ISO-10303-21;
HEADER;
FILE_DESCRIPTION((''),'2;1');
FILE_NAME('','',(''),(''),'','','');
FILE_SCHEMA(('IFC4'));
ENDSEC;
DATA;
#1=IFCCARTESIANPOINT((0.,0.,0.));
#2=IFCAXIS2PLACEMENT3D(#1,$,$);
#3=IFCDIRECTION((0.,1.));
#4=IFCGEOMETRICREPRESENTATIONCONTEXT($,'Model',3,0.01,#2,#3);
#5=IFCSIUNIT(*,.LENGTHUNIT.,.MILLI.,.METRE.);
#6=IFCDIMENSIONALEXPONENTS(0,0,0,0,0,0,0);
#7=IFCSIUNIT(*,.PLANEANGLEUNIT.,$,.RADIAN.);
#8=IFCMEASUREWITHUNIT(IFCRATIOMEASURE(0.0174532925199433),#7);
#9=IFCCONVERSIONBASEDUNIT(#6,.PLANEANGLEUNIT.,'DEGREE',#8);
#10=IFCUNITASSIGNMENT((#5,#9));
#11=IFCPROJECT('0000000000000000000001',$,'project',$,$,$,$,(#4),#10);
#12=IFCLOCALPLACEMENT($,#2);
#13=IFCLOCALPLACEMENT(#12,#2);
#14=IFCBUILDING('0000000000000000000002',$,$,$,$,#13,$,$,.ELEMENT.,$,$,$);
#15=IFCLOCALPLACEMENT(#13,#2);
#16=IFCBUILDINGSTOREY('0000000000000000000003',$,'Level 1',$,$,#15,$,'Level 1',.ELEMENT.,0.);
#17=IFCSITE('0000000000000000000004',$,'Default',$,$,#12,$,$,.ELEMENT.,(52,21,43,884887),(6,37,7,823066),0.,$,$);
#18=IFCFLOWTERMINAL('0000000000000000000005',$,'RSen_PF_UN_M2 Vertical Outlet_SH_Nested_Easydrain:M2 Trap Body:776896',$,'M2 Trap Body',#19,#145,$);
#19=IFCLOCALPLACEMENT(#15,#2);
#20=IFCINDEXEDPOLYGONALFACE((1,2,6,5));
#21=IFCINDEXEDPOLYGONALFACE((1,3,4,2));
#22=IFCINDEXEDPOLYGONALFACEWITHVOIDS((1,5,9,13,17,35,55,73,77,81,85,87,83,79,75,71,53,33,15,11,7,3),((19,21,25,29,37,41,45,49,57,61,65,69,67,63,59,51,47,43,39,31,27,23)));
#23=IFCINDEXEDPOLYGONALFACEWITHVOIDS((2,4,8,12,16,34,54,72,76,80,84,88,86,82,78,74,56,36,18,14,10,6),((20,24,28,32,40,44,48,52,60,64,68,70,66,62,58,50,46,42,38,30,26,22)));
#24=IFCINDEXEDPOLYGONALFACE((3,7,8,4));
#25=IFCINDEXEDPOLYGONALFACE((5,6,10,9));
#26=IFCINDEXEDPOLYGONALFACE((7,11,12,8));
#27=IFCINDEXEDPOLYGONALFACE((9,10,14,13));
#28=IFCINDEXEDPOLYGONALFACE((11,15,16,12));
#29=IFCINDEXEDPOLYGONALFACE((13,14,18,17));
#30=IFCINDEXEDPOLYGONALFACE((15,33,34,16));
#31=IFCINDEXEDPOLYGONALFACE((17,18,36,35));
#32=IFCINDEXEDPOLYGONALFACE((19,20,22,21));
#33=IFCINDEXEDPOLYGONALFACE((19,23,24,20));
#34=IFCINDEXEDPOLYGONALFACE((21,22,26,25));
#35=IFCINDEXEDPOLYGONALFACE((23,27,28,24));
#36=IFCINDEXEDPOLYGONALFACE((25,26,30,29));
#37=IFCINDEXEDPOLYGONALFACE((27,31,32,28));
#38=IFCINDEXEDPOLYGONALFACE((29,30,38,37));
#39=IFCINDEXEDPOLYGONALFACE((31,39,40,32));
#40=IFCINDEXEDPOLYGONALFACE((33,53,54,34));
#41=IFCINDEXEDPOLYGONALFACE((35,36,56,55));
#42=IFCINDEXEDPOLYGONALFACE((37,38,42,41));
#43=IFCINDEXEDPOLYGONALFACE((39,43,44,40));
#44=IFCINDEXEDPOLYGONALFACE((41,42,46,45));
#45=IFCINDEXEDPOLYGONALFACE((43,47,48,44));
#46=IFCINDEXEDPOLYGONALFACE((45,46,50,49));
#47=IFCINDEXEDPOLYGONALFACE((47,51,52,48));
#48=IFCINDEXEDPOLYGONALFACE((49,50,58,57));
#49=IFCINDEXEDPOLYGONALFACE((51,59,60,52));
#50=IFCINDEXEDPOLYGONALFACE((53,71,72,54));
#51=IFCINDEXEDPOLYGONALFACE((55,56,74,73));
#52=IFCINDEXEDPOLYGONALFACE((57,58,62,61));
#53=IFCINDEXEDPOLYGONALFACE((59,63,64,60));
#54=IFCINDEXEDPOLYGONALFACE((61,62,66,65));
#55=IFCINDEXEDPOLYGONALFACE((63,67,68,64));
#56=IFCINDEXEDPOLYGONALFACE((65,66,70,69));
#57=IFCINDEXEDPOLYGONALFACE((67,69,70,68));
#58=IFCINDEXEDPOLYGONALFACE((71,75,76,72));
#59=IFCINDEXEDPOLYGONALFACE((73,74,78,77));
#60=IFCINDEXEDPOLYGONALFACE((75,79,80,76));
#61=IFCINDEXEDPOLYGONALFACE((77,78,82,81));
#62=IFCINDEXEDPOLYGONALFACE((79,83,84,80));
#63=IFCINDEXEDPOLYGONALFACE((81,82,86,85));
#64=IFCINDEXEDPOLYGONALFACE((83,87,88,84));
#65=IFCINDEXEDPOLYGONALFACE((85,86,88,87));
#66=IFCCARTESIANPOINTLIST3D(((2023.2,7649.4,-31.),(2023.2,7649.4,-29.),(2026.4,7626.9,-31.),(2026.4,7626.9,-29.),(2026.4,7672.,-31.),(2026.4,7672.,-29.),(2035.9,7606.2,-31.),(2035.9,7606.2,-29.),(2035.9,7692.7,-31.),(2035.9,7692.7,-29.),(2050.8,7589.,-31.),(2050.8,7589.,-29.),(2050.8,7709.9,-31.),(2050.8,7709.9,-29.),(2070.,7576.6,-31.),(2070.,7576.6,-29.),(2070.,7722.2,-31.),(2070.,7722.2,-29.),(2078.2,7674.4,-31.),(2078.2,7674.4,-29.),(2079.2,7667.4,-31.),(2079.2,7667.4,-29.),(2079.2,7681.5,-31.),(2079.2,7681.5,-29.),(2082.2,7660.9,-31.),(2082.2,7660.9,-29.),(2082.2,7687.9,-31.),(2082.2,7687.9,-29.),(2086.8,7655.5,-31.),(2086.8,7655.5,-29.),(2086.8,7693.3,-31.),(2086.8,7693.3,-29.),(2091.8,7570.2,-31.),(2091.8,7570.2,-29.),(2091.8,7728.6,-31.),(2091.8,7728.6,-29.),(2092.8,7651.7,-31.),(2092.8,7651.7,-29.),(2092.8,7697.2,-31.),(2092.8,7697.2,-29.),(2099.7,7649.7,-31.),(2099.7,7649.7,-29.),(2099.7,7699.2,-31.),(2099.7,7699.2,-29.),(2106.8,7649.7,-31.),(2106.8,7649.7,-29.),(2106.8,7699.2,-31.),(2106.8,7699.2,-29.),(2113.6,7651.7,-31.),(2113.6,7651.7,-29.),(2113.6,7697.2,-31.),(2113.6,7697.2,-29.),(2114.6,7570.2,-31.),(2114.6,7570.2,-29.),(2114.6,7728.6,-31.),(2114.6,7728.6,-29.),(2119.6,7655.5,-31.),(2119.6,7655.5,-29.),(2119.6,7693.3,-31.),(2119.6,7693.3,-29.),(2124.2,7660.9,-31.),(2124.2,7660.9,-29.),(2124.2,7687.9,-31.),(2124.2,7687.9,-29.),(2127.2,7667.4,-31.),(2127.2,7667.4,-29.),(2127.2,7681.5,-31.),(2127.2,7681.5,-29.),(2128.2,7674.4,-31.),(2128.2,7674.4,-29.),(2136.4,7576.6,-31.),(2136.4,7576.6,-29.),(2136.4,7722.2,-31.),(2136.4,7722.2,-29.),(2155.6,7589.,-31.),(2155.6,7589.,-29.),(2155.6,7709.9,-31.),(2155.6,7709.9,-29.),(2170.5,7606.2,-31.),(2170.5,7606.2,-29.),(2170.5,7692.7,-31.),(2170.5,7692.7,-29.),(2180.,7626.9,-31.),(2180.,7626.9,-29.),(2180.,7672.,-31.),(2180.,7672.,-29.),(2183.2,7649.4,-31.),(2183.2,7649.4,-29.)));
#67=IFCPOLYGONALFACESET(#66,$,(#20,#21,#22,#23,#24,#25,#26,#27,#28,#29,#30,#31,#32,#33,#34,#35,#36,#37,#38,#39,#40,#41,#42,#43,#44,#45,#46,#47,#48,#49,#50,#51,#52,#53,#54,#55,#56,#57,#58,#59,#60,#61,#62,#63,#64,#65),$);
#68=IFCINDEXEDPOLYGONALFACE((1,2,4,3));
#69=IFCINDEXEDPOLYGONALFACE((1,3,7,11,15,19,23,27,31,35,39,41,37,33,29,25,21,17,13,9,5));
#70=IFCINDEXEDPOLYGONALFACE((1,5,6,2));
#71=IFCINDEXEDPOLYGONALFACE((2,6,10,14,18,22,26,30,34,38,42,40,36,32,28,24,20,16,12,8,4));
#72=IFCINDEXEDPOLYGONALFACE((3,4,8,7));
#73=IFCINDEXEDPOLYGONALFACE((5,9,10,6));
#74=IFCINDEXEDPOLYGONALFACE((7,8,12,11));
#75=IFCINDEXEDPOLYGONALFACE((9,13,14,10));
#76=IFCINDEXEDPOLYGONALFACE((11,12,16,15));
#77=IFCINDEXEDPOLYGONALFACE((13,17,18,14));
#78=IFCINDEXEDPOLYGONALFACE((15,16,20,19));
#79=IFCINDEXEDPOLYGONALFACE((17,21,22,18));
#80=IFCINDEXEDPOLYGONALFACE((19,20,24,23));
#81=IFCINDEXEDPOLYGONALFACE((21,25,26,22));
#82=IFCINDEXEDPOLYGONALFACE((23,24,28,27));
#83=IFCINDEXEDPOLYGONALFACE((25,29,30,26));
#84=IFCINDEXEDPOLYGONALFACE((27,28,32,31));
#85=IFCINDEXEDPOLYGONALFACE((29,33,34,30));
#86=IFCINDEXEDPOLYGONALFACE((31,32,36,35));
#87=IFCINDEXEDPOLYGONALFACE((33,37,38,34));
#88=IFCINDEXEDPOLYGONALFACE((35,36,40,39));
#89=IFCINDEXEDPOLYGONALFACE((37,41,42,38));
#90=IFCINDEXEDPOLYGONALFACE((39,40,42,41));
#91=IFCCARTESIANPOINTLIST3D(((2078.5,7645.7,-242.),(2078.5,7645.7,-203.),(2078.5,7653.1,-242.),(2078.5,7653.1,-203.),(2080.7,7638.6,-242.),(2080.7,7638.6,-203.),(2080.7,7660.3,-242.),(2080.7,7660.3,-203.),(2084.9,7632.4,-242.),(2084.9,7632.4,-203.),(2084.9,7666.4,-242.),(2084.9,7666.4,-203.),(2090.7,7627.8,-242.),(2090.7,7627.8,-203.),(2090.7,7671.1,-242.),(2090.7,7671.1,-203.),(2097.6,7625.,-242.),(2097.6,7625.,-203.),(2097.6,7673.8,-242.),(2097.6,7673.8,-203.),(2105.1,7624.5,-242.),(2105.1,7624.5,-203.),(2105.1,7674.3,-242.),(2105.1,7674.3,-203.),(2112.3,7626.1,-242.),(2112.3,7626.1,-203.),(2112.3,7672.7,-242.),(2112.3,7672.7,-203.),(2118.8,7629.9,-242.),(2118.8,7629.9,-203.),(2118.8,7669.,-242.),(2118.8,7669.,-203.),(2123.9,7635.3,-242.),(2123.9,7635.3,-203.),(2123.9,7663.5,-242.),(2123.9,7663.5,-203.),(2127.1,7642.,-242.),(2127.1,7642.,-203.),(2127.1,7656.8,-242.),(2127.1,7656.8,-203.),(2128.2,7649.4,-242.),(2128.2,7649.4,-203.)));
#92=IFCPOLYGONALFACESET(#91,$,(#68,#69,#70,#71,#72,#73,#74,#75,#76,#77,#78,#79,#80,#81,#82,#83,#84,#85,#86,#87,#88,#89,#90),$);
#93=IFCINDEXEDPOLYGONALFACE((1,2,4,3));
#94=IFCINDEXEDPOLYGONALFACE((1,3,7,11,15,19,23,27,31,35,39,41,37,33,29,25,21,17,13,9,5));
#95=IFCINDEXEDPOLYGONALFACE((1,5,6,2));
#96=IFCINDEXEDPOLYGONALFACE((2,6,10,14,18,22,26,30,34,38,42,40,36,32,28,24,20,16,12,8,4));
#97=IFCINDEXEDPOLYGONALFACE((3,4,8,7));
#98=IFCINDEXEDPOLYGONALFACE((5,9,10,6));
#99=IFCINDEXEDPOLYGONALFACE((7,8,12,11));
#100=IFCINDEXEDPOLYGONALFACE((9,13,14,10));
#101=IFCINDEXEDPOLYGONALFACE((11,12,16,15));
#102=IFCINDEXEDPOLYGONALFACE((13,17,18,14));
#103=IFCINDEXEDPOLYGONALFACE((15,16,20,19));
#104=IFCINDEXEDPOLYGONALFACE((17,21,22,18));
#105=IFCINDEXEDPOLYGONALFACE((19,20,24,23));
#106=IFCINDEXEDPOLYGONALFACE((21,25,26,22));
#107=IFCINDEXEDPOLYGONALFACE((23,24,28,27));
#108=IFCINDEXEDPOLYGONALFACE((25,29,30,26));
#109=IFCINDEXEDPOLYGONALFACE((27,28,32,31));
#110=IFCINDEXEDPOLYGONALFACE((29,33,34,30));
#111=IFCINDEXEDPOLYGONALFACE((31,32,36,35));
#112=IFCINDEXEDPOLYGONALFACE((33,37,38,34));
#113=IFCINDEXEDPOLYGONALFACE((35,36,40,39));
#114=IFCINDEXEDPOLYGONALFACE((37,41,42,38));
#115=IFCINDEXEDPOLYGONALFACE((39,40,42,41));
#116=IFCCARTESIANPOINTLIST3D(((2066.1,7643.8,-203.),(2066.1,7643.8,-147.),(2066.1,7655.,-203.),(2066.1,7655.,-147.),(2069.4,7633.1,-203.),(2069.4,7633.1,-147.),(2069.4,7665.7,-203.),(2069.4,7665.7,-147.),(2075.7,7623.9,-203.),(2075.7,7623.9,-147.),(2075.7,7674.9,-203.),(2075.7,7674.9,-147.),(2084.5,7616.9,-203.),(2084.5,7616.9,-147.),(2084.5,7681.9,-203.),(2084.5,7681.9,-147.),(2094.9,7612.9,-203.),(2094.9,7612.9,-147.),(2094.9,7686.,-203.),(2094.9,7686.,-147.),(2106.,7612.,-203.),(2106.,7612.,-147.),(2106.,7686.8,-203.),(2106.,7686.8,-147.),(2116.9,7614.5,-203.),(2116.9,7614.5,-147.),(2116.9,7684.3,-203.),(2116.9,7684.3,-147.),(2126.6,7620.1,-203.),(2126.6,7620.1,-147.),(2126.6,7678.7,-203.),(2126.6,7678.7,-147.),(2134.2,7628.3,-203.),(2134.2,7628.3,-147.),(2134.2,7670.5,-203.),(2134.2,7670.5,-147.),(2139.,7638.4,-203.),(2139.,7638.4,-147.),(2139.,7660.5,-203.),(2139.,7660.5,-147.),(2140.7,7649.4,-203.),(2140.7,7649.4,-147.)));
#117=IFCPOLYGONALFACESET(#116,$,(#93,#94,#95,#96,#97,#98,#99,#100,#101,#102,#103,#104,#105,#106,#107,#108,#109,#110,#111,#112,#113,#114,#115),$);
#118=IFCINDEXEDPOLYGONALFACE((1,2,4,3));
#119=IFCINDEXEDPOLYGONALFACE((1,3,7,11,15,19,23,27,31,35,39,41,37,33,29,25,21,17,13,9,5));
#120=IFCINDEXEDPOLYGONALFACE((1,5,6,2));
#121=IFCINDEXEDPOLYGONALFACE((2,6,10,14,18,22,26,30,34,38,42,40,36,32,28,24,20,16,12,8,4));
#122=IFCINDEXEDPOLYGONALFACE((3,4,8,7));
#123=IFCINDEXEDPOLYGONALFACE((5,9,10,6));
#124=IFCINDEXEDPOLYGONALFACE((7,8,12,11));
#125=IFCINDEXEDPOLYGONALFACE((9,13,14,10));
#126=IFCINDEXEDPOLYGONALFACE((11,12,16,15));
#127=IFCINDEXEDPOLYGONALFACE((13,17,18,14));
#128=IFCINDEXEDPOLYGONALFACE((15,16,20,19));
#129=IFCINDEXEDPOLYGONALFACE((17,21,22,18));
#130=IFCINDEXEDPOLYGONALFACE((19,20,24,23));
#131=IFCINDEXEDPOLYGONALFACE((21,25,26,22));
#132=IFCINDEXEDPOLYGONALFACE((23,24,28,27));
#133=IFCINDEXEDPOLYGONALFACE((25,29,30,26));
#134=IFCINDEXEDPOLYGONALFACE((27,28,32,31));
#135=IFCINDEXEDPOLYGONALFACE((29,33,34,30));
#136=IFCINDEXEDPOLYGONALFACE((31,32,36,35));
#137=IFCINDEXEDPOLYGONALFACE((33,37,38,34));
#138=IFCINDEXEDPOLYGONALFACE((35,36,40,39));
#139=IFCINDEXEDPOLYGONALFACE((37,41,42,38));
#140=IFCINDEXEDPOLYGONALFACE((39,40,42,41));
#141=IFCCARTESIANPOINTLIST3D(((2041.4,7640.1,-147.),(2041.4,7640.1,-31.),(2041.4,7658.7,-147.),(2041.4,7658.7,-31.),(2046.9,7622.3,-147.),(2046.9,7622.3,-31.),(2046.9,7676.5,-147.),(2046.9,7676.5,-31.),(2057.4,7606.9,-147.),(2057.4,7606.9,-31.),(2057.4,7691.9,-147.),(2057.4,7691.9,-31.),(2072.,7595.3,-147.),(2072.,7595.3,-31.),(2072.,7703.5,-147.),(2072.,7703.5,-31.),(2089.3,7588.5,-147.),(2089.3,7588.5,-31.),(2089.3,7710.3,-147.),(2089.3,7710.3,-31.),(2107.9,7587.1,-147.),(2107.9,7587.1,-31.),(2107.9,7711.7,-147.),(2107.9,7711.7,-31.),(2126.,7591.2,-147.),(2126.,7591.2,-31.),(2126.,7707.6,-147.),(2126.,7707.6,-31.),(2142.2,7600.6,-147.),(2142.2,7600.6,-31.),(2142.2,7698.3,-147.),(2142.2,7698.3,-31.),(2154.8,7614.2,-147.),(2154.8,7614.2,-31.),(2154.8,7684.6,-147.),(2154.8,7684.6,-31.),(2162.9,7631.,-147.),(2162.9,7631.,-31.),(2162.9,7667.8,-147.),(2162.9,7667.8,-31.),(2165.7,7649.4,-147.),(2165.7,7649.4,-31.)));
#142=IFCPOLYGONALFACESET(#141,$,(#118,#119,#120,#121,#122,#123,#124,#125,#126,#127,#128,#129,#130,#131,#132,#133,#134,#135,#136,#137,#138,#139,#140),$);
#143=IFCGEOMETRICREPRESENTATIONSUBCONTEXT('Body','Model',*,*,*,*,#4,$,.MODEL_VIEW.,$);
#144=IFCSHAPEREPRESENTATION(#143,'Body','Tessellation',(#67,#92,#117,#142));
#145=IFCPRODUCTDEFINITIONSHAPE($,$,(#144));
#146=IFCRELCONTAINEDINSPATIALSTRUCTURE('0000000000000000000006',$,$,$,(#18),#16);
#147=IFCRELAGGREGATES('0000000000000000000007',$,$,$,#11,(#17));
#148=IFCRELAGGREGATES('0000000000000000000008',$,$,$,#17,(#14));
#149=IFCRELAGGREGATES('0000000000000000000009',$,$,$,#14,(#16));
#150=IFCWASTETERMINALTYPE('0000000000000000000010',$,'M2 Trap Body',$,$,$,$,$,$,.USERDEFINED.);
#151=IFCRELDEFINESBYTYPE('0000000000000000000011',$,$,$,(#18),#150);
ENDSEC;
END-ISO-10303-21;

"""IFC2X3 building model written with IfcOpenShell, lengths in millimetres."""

from ifc_helpers import new_model, entity, si_unit, converted_unit, direction, frame, frame_2d, origin, origin_2d_with_axis, place, context, subcontext, project, spatial, circle_curve, parameter, trimmed, segment, composite_curve, circle, outline, extrude, source, transform, mapped, type_object, type_shapes, element, save


model = new_model("IFC2X3")

# Units and contexts
model_context = context("Model", 3, precision=0.01, world=origin(), true_north=direction((0.0, 1.0)))
body_context = subcontext(model_context, "Body", "Model", "MODEL_VIEW")
ifc_project = project(units=[si_unit("LENGTHUNIT", "METRE", prefix="MILLI"), converted_unit("PLANEANGLEUNIT", "DEGREE", entity("IfcRatioMeasure", 0.0174532925199433), si_unit("PLANEANGLEUNIT", "RADIAN"), dimensions=[0, 0, 0, 0, 0, 0, 0])], contexts=[model_context])

# Site, building, storey
site_placement = place(None, origin())
site = spatial("IfcSite", under=ifc_project, at=site_placement, Name="Default", CompositionType="ELEMENT", RefLatitude=(52, 21, 43, 884887), RefLongitude=(6, 37, 7, 823066), RefElevation=0.0)
building_placement = place(site_placement, origin())
building = spatial("IfcBuilding", under=site, at=building_placement, CompositionType="ELEMENT")
storey_placement = place(building_placement, origin())
storey = spatial("IfcBuildingStorey", under=building, at=storey_placement, Name="Level 1", LongName="Level 1", CompositionType="ELEMENT", Elevation=0.0)

# Flow terminal
waste_terminal_type_1 = type_object("IfcWasteTerminalType", Name="M2 Trap Body", PredefinedType="USERDEFINED")
shared_shape_1 = source(origin(), body_context, "Body", "SweptSolid", [
    extrude(outline(composite_curve([segment(trimmed(circle_curve(origin_2d_with_axis(), 80.0), [parameter(0.0)], [parameter(180.0)], True, "PARAMETER"), True, "CONTINUOUS"), segment(trimmed(circle_curve(origin_2d_with_axis(), 80.0), [parameter(180.0)], [parameter(360.0)], True, "PARAMETER"), True, "CONTINUOUS")], self_intersect=False), holes=[composite_curve([segment(trimmed(circle_curve(frame_2d((0.0, 25.0), x_axis=(1.0, 0.0)), 25.0), [parameter(180.0)], [parameter(360.0)], True, "PARAMETER"), False, "CONTINUOUS"), segment(trimmed(circle_curve(frame_2d((0.0, 25.0), x_axis=(1.0, 0.0)), 25.0), [parameter(0.0)], [parameter(180.0)], True, "PARAMETER"), False, "CONTINUOUS")], self_intersect=False)]), frame((0.0, -25.0, -2.0)), (0.0, 0.0, 1.0), 2.0),
    extrude(circle(Radius=25.0, at=frame_2d((0.0, 0.0), x_axis=(1.0, 0.0))), frame((0.0, -25.0, -213.0)), (0.0, 0.0, 1.0), 39.0),
    extrude(circle(Radius=37.5, at=frame_2d((0.0, 0.0), x_axis=(1.0, 0.0))), frame((0.0, -25.0, -174.0)), (0.0, 0.0, 1.0), 56.0),
    extrude(circle(Radius=62.5, at=frame_2d((0.0, 0.0), x_axis=(1.0, 0.0))), frame((0.0, -25.0, -118.0)), (0.0, 0.0, 1.0), 116.0),
])
type_shapes(waste_terminal_type_1, [shared_shape_1])
for number, where, name in (
    (1, (2103.2, 7674.4, -29.0), "RSen_PF_UN_M2 Vertical Outlet_SH_Nested_Easydrain:M2 Trap Body:776896"),
):
    element("IfcFlowTerminal", number, at=place(storey_placement, frame(where)), inside=storey, type_object=waste_terminal_type_1, Name=name, ObjectType="M2 Trap Body", context=body_context, shape_type="MappedRepresentation", body=[
        mapped(shared_shape_1, transform((0.0, 0.0, 0.0), scale=1.0)),
    ])

save(model, "model.ifc")
